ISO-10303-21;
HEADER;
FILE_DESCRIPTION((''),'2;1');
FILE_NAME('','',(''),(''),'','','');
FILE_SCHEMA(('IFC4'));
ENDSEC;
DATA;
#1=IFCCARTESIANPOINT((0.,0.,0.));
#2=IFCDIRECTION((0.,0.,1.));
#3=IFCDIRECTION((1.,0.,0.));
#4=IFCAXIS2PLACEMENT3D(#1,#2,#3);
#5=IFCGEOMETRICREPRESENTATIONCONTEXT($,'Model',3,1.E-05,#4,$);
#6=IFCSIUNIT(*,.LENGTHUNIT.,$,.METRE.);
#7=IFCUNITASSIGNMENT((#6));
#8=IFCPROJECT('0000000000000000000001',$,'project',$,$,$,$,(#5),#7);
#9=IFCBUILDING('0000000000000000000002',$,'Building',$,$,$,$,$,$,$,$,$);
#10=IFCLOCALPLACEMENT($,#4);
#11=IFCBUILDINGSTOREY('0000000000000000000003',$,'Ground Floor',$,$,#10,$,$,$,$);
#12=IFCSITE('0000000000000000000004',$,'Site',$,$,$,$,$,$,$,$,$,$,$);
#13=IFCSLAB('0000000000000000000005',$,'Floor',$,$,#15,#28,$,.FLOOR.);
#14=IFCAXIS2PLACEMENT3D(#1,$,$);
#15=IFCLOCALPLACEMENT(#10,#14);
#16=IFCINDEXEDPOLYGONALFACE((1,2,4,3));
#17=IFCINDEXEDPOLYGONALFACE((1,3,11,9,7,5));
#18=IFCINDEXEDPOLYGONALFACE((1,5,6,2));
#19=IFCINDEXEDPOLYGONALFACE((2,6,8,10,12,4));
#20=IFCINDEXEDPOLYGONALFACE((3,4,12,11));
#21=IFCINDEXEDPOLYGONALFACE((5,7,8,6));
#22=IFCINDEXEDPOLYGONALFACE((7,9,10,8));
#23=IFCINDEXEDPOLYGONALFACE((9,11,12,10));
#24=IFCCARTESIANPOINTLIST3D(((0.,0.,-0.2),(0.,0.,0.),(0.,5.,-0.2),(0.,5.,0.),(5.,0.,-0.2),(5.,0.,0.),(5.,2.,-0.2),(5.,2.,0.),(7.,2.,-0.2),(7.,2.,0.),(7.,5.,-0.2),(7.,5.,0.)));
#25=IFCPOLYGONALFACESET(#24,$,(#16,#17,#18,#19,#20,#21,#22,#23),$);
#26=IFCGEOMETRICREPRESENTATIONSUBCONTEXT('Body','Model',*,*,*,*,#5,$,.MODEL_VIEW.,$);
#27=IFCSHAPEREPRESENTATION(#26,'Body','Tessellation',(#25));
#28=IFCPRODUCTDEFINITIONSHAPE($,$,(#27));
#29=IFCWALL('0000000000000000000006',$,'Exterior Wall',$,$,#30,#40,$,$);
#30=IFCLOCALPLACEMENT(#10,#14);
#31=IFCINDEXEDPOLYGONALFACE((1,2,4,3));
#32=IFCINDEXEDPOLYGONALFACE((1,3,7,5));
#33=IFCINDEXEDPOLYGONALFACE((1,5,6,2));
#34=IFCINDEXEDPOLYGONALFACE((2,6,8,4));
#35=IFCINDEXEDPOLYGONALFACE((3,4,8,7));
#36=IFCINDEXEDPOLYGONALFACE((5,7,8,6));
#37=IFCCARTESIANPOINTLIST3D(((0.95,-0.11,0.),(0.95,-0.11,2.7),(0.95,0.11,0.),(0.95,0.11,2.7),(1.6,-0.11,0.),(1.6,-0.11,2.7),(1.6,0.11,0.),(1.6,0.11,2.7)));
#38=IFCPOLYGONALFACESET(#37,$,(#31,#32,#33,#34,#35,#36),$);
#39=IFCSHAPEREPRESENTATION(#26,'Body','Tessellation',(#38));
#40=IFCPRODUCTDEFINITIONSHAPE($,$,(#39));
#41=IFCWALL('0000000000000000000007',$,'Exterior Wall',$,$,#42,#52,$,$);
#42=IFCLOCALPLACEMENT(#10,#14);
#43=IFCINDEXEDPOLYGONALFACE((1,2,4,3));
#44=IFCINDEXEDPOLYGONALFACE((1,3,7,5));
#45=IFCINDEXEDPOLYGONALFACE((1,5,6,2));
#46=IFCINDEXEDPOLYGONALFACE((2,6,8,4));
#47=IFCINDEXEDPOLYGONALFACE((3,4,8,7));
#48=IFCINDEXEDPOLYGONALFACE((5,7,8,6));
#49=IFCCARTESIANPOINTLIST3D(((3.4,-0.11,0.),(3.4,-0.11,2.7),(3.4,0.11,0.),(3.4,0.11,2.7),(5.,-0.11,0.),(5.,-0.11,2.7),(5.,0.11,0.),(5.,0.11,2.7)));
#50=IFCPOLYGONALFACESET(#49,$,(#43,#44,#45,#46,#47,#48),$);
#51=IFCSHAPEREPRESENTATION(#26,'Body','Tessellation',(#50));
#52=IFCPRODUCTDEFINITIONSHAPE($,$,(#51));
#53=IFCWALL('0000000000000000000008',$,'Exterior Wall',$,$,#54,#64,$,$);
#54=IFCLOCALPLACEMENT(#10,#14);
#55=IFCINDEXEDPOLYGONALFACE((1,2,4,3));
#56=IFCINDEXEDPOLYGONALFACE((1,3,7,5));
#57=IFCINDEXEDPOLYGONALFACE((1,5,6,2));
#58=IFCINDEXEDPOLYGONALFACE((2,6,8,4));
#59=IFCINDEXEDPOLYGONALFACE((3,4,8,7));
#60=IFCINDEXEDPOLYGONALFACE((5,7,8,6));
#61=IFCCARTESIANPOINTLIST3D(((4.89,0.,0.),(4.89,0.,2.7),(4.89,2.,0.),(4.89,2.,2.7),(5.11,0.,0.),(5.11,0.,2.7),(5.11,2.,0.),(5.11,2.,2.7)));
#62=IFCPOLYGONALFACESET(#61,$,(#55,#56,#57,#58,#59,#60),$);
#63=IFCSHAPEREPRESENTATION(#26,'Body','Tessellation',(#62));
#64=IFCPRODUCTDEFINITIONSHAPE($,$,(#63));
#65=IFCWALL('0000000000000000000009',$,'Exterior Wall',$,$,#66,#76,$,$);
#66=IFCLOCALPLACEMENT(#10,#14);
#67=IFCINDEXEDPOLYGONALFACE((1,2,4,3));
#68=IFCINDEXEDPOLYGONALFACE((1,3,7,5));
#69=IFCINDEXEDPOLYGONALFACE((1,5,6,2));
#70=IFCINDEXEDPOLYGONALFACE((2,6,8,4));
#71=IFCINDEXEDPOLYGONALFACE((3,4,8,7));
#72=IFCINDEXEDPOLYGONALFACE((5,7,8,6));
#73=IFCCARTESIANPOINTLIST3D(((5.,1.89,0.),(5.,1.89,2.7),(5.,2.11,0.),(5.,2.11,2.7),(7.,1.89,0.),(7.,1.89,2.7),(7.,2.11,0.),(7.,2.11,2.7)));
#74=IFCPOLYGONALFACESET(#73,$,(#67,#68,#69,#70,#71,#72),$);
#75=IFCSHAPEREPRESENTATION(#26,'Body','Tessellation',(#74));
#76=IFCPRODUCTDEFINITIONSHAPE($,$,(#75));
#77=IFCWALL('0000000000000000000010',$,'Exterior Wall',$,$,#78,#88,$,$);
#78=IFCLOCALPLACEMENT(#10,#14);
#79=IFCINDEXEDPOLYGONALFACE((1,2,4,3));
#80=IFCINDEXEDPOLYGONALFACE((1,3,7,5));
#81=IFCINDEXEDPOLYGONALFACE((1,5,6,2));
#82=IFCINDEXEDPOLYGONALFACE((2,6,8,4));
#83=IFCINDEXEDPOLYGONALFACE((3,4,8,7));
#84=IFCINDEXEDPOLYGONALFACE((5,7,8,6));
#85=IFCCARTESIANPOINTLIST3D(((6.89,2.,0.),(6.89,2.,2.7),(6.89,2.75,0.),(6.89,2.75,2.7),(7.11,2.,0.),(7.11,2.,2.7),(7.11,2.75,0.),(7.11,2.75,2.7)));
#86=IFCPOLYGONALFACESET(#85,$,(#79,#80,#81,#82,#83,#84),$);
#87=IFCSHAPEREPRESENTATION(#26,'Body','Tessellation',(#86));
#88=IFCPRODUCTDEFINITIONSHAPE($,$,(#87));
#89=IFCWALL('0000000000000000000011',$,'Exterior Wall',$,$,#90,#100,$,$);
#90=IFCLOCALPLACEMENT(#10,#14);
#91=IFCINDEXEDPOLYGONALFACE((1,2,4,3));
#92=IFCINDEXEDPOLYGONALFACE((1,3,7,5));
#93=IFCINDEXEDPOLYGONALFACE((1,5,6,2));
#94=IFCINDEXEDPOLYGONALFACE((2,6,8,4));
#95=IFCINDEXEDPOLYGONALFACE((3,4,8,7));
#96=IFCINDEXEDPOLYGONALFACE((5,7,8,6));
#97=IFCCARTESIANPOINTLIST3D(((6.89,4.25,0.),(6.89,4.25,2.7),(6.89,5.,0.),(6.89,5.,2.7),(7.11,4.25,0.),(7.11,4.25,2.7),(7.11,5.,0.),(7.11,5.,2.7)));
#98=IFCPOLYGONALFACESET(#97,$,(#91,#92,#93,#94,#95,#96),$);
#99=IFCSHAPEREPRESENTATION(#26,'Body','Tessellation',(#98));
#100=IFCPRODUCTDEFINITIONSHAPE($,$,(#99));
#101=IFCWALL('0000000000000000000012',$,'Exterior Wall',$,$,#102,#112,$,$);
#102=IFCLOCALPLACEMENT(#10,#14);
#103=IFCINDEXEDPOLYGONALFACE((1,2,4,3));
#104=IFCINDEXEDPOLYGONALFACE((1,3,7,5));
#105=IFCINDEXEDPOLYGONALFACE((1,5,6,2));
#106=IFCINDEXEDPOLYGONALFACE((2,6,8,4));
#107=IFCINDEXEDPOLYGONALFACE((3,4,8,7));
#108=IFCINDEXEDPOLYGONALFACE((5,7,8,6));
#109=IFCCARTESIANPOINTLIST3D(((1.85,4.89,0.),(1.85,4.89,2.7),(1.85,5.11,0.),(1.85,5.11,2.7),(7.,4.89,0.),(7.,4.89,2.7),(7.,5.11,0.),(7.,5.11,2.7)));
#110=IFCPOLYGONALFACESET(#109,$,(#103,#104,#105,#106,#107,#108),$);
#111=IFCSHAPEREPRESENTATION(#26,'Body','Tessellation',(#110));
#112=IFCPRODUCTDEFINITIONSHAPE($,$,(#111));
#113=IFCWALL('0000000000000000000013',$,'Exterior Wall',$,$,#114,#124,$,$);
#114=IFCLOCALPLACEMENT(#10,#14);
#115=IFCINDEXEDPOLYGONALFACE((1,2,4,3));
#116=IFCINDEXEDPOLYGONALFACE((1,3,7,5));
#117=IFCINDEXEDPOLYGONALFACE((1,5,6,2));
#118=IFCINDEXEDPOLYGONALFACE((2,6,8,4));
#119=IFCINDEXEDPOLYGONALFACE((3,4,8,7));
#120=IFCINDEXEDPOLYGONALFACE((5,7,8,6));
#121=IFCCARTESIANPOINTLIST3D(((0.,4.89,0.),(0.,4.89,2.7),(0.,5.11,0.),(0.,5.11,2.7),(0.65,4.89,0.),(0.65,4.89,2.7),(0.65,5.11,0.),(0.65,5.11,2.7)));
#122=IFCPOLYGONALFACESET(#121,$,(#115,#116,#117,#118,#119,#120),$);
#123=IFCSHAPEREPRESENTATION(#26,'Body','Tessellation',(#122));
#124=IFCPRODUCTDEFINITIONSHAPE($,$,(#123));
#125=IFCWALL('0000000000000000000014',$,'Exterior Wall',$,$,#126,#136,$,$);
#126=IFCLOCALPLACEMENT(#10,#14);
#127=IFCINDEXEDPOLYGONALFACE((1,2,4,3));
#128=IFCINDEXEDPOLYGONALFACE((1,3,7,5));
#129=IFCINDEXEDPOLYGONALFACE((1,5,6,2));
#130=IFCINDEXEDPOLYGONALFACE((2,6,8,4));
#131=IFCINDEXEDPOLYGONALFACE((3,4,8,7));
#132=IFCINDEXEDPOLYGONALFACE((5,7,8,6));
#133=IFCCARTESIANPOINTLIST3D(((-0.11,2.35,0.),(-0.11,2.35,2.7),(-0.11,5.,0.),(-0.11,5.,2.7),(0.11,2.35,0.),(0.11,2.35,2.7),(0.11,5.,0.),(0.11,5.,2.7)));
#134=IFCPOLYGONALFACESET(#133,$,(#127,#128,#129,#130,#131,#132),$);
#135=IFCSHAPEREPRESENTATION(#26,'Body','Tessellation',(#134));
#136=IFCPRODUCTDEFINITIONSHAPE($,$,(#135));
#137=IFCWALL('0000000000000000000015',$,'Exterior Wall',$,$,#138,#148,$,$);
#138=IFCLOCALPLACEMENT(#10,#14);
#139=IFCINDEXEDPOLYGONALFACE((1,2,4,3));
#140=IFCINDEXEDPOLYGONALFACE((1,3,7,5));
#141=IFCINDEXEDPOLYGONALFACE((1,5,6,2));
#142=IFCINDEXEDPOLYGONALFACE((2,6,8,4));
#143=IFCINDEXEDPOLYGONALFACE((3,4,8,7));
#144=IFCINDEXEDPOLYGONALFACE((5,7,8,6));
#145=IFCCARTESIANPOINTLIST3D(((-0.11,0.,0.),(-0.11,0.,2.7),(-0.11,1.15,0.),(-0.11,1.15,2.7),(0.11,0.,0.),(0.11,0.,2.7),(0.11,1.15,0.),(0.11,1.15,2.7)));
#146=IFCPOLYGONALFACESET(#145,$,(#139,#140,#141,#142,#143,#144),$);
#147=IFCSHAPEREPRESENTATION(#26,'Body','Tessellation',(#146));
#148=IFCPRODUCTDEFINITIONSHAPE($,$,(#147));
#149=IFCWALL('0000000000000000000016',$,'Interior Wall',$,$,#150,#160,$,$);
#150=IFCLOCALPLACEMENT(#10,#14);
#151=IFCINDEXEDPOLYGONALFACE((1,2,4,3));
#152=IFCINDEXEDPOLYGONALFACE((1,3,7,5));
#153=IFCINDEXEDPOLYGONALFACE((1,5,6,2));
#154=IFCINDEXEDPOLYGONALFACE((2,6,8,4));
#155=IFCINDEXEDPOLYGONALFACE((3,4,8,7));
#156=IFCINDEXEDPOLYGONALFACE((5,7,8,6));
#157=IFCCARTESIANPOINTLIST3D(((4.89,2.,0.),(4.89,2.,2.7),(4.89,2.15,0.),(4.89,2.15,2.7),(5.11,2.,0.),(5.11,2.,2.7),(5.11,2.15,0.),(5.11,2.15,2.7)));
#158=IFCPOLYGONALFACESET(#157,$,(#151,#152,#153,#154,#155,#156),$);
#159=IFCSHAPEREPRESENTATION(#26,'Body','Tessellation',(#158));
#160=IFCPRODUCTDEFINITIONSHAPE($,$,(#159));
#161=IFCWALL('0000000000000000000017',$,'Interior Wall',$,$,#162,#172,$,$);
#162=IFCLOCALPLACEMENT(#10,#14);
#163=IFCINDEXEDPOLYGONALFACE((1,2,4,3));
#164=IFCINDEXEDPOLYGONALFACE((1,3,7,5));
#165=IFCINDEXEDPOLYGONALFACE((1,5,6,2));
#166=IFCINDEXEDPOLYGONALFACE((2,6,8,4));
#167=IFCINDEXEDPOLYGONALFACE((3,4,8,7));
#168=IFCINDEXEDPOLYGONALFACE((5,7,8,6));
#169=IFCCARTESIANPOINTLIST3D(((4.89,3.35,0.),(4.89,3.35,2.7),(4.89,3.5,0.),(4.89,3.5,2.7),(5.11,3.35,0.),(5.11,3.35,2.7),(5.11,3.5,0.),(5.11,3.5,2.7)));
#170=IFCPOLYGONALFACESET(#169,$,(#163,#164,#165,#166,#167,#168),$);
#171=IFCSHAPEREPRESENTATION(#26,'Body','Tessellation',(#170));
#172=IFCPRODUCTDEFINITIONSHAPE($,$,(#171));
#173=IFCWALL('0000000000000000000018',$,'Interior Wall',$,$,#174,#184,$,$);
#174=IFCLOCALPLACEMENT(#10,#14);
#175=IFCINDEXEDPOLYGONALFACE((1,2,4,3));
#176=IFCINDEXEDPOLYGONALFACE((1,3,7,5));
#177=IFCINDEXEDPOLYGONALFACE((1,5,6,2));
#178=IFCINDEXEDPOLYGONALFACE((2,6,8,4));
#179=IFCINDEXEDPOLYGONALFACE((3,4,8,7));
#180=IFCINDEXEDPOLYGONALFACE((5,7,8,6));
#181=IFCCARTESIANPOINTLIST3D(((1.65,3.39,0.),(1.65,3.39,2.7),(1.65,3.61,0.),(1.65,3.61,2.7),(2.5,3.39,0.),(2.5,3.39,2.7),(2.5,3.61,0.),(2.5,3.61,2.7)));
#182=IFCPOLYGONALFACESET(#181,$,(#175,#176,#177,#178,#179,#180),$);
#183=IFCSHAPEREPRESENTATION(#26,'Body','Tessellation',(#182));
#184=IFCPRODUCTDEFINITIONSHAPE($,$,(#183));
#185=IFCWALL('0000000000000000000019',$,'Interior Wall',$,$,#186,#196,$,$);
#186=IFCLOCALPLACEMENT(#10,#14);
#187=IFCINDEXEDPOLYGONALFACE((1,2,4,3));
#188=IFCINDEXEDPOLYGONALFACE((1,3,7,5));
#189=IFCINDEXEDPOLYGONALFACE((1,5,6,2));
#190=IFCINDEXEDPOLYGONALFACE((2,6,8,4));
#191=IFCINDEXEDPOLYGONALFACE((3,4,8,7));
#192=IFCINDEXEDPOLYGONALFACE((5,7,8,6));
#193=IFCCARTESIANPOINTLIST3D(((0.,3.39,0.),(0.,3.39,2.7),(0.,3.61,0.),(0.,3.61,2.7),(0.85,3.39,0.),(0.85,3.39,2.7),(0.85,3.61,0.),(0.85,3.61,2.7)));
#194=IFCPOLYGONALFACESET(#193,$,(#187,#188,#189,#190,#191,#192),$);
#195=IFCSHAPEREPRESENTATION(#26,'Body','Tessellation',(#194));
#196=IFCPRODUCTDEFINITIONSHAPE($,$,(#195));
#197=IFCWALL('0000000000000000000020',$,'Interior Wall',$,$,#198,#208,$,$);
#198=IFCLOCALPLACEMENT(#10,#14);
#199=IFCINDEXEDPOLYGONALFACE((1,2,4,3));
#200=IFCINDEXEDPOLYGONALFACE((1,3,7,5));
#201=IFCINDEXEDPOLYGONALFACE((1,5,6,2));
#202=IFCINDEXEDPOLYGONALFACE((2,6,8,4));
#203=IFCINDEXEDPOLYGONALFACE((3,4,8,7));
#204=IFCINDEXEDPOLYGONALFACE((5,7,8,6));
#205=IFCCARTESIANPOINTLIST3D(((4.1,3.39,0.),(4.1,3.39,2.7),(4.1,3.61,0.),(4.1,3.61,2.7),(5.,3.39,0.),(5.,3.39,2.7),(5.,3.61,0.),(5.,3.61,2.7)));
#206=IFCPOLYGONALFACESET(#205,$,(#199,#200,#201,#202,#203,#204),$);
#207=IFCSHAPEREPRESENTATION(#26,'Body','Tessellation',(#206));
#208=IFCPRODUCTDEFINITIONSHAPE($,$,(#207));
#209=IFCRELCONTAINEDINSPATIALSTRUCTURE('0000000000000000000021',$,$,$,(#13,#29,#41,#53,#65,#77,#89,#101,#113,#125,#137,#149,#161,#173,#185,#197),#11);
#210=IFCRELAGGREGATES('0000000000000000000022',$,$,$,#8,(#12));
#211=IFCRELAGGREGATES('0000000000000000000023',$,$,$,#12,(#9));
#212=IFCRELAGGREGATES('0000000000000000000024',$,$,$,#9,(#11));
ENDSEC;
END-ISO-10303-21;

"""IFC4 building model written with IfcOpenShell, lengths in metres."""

from ifc_helpers import new_model, si_unit, frame, origin_with_axes, place, context, subcontext, project, spatial, indexed_curve, outline, extrude, element, save


model = new_model("IFC4")

# Units and contexts
model_context = context("Model", 3, precision=1e-05, world=origin_with_axes())
body_context = subcontext(model_context, "Body", "Model", "MODEL_VIEW")
ifc_project = project(units=[si_unit("LENGTHUNIT", "METRE")], contexts=[model_context])

# Site, building, storey
site = spatial("IfcSite", under=ifc_project, Name="Site")
building = spatial("IfcBuilding", under=site, Name="Building")
storey_placement = place(None, origin_with_axes())
storey = spatial("IfcBuildingStorey", under=building, at=storey_placement, Name="Ground Floor")

# Slab
slab_placement = place(storey_placement, frame((0.0, 0.0, -0.2), z_axis=(0.0, 0.0, 1.0), x_axis=(1.0, 0.0, 0.0)))
element("IfcSlab", 1, at=slab_placement, inside=storey, Name="Floor", PredefinedType="FLOOR", context=body_context, shape_type="SweptSolid", body=[
    extrude(outline(indexed_curve([(0.0, 0.0), (5.0, 0.0), (5.0, 2.0), (7.0, 2.0), (7.0, 5.0), (0.0, 5.0)])), None, (0.0, 0.0, 1.0), 0.2),
])

# Walls
wall_1_placement = place(storey_placement, frame((0.95, 0.0, 0.0), z_axis=(0.0, 0.0, 1.0), x_axis=(1.0, 0.0, 0.0)))
element("IfcWall", 2, at=wall_1_placement, inside=storey, Name="Exterior Wall", context=body_context, shape_type="SweptSolid", body=[
    extrude(outline(indexed_curve([(0.0, 0.0), (0.0, 0.22), (0.65, 0.22), (0.65, 0.0), (0.0, 0.0)], self_intersect=False)), frame((0.0, -0.11, 0.0), z_axis=(0.0, 0.0, 1.0), x_axis=(1.0, 0.0, 0.0)), (0.0, 0.0, 1.0), 2.7),
])
wall_2_placement = place(storey_placement, frame((3.4, 0.0, 0.0), z_axis=(0.0, 0.0, 1.0), x_axis=(1.0, 0.0, 0.0)))
element("IfcWall", 3, at=wall_2_placement, inside=storey, Name="Exterior Wall", context=body_context, shape_type="SweptSolid", body=[
    extrude(outline(indexed_curve([(0.0, 0.0), (0.0, 0.22), (1.6, 0.22), (1.6, 0.0), (0.0, 0.0)], self_intersect=False)), frame((0.0, -0.11, 0.0), z_axis=(0.0, 0.0, 1.0), x_axis=(1.0, 0.0, 0.0)), (0.0, 0.0, 1.0), 2.7),
])
for number, where, z_axis, x_axis, name in (
    (4, (5.0, 0.0, 0.0), (0.0, 0.0, 1.0), (0.0, 1.0, 0.0), "Exterior Wall"),
    (5, (5.0, 2.0, 0.0), (0.0, 0.0, 1.0), (1.0, 0.0, 0.0), "Exterior Wall"),
):
    element("IfcWall", number, at=place(storey_placement, frame(where, z_axis=z_axis, x_axis=x_axis)), inside=storey, Name=name, context=body_context, shape_type="SweptSolid", body=[
        extrude(outline(indexed_curve([(0.0, 0.0), (0.0, 0.22), (2.0, 0.22), (2.0, 0.0), (0.0, 0.0)], self_intersect=False)), frame((0.0, -0.11, 0.0), z_axis=(0.0, 0.0, 1.0), x_axis=(1.0, 0.0, 0.0)), (0.0, 0.0, 1.0), 2.7),
    ])
for number, where, z_axis, x_axis, name in (
    (6, (7.0, 2.0, 0.0), (0.0, 0.0, 1.0), (0.0, 1.0, 0.0), "Exterior Wall"),
    (7, (7.0, 4.25, 0.0), (0.0, 0.0, 1.0), (0.0, 1.0, 0.0), "Exterior Wall"),
):
    element("IfcWall", number, at=place(storey_placement, frame(where, z_axis=z_axis, x_axis=x_axis)), inside=storey, Name=name, context=body_context, shape_type="SweptSolid", body=[
        extrude(outline(indexed_curve([(0.0, 0.0), (0.0, 0.22), (0.75, 0.22), (0.75, 0.0), (0.0, 0.0)], self_intersect=False)), frame((0.0, -0.11, 0.0), z_axis=(0.0, 0.0, 1.0), x_axis=(1.0, 0.0, 0.0)), (0.0, 0.0, 1.0), 2.7),
    ])
wall_3_placement = place(storey_placement, frame((7.0, 5.0, 0.0), z_axis=(0.0, 0.0, 1.0), x_axis=(-1.0, 0.0, 0.0)))
element("IfcWall", 8, at=wall_3_placement, inside=storey, Name="Exterior Wall", context=body_context, shape_type="SweptSolid", body=[
    extrude(outline(indexed_curve([(0.0, 0.0), (0.0, 0.22), (5.15, 0.22), (5.15, 0.0), (0.0, 0.0)], self_intersect=False)), frame((0.0, -0.11, 0.0), z_axis=(0.0, 0.0, 1.0), x_axis=(1.0, 0.0, 0.0)), (0.0, 0.0, 1.0), 2.7),
])
wall_4_placement = place(storey_placement, frame((0.65, 5.0, 0.0), z_axis=(0.0, 0.0, 1.0), x_axis=(-1.0, 0.0, 0.0)))
element("IfcWall", 9, at=wall_4_placement, inside=storey, Name="Exterior Wall", context=body_context, shape_type="SweptSolid", body=[
    extrude(outline(indexed_curve([(0.0, 0.0), (0.0, 0.22), (0.65, 0.22), (0.65, 0.0), (0.0, 0.0)], self_intersect=False)), frame((0.0, -0.11, 0.0), z_axis=(0.0, 0.0, 1.0), x_axis=(1.0, 0.0, 0.0)), (0.0, 0.0, 1.0), 2.7),
])
wall_5_placement = place(storey_placement, frame((0.0, 5.0, 0.0), z_axis=(0.0, 0.0, 1.0), x_axis=(0.0, -1.0, 0.0)))
element("IfcWall", 10, at=wall_5_placement, inside=storey, Name="Exterior Wall", context=body_context, shape_type="SweptSolid", body=[
    extrude(outline(indexed_curve([(0.0, 0.0), (0.0, 0.22), (2.65, 0.22), (2.65, 0.0), (0.0, 0.0)], self_intersect=False)), frame((0.0, -0.11, 0.0), z_axis=(0.0, 0.0, 1.0), x_axis=(1.0, 0.0, 0.0)), (0.0, 0.0, 1.0), 2.7),
])
wall_6_placement = place(storey_placement, frame((0.0, 1.15, 0.0), z_axis=(0.0, 0.0, 1.0), x_axis=(0.0, -1.0, 0.0)))
element("IfcWall", 11, at=wall_6_placement, inside=storey, Name="Exterior Wall", context=body_context, shape_type="SweptSolid", body=[
    extrude(outline(indexed_curve([(0.0, 0.0), (0.0, 0.22), (1.15, 0.22), (1.15, 0.0), (0.0, 0.0)], self_intersect=False)), frame((0.0, -0.11, 0.0), z_axis=(0.0, 0.0, 1.0), x_axis=(1.0, 0.0, 0.0)), (0.0, 0.0, 1.0), 2.7),
])
for number, where, z_axis, x_axis, name in (
    (12, (5.0, 2.0, 0.0), (0.0, 0.0, 1.0), (0.0, 1.0, 0.0), "Interior Wall"),
    (13, (5.0, 3.35, 0.0), (0.0, 0.0, 1.0), (0.0, 1.0, 0.0), "Interior Wall"),
):
    element("IfcWall", number, at=place(storey_placement, frame(where, z_axis=z_axis, x_axis=x_axis)), inside=storey, Name=name, context=body_context, shape_type="SweptSolid", body=[
        extrude(outline(indexed_curve([(0.0, 0.0), (0.0, 0.22), (0.15, 0.22), (0.15, 0.0), (0.0, 0.0)], self_intersect=False)), frame((0.0, -0.11, 0.0), z_axis=(0.0, 0.0, 1.0), x_axis=(1.0, 0.0, 0.0)), (0.0, 0.0, 1.0), 2.7),
    ])
for number, where, z_axis, x_axis, name in (
    (14, (2.5, 3.5, 0.0), (0.0, 0.0, 1.0), (-1.0, 0.0, 0.0), "Interior Wall"),
    (15, (0.85, 3.5, 0.0), (0.0, 0.0, 1.0), (-1.0, 0.0, 0.0), "Interior Wall"),
):
    element("IfcWall", number, at=place(storey_placement, frame(where, z_axis=z_axis, x_axis=x_axis)), inside=storey, Name=name, context=body_context, shape_type="SweptSolid", body=[
        extrude(outline(indexed_curve([(0.0, 0.0), (0.0, 0.22), (0.85, 0.22), (0.85, 0.0), (0.0, 0.0)], self_intersect=False)), frame((0.0, -0.11, 0.0), z_axis=(0.0, 0.0, 1.0), x_axis=(1.0, 0.0, 0.0)), (0.0, 0.0, 1.0), 2.7),
    ])
wall_7_placement = place(storey_placement, frame((5.0, 3.5, 0.0), z_axis=(0.0, 0.0, 1.0), x_axis=(-1.0, 0.0, 0.0)))
element("IfcWall", 16, at=wall_7_placement, inside=storey, Name="Interior Wall", context=body_context, shape_type="SweptSolid", body=[
    extrude(outline(indexed_curve([(0.0, 0.0), (0.0, 0.22), (0.9, 0.22), (0.9, 0.0), (0.0, 0.0)], self_intersect=False)), frame((0.0, -0.11, 0.0), z_axis=(0.0, 0.0, 1.0), x_axis=(1.0, 0.0, 0.0)), (0.0, 0.0, 1.0), 2.7),
])

save(model, "model.ifc")
